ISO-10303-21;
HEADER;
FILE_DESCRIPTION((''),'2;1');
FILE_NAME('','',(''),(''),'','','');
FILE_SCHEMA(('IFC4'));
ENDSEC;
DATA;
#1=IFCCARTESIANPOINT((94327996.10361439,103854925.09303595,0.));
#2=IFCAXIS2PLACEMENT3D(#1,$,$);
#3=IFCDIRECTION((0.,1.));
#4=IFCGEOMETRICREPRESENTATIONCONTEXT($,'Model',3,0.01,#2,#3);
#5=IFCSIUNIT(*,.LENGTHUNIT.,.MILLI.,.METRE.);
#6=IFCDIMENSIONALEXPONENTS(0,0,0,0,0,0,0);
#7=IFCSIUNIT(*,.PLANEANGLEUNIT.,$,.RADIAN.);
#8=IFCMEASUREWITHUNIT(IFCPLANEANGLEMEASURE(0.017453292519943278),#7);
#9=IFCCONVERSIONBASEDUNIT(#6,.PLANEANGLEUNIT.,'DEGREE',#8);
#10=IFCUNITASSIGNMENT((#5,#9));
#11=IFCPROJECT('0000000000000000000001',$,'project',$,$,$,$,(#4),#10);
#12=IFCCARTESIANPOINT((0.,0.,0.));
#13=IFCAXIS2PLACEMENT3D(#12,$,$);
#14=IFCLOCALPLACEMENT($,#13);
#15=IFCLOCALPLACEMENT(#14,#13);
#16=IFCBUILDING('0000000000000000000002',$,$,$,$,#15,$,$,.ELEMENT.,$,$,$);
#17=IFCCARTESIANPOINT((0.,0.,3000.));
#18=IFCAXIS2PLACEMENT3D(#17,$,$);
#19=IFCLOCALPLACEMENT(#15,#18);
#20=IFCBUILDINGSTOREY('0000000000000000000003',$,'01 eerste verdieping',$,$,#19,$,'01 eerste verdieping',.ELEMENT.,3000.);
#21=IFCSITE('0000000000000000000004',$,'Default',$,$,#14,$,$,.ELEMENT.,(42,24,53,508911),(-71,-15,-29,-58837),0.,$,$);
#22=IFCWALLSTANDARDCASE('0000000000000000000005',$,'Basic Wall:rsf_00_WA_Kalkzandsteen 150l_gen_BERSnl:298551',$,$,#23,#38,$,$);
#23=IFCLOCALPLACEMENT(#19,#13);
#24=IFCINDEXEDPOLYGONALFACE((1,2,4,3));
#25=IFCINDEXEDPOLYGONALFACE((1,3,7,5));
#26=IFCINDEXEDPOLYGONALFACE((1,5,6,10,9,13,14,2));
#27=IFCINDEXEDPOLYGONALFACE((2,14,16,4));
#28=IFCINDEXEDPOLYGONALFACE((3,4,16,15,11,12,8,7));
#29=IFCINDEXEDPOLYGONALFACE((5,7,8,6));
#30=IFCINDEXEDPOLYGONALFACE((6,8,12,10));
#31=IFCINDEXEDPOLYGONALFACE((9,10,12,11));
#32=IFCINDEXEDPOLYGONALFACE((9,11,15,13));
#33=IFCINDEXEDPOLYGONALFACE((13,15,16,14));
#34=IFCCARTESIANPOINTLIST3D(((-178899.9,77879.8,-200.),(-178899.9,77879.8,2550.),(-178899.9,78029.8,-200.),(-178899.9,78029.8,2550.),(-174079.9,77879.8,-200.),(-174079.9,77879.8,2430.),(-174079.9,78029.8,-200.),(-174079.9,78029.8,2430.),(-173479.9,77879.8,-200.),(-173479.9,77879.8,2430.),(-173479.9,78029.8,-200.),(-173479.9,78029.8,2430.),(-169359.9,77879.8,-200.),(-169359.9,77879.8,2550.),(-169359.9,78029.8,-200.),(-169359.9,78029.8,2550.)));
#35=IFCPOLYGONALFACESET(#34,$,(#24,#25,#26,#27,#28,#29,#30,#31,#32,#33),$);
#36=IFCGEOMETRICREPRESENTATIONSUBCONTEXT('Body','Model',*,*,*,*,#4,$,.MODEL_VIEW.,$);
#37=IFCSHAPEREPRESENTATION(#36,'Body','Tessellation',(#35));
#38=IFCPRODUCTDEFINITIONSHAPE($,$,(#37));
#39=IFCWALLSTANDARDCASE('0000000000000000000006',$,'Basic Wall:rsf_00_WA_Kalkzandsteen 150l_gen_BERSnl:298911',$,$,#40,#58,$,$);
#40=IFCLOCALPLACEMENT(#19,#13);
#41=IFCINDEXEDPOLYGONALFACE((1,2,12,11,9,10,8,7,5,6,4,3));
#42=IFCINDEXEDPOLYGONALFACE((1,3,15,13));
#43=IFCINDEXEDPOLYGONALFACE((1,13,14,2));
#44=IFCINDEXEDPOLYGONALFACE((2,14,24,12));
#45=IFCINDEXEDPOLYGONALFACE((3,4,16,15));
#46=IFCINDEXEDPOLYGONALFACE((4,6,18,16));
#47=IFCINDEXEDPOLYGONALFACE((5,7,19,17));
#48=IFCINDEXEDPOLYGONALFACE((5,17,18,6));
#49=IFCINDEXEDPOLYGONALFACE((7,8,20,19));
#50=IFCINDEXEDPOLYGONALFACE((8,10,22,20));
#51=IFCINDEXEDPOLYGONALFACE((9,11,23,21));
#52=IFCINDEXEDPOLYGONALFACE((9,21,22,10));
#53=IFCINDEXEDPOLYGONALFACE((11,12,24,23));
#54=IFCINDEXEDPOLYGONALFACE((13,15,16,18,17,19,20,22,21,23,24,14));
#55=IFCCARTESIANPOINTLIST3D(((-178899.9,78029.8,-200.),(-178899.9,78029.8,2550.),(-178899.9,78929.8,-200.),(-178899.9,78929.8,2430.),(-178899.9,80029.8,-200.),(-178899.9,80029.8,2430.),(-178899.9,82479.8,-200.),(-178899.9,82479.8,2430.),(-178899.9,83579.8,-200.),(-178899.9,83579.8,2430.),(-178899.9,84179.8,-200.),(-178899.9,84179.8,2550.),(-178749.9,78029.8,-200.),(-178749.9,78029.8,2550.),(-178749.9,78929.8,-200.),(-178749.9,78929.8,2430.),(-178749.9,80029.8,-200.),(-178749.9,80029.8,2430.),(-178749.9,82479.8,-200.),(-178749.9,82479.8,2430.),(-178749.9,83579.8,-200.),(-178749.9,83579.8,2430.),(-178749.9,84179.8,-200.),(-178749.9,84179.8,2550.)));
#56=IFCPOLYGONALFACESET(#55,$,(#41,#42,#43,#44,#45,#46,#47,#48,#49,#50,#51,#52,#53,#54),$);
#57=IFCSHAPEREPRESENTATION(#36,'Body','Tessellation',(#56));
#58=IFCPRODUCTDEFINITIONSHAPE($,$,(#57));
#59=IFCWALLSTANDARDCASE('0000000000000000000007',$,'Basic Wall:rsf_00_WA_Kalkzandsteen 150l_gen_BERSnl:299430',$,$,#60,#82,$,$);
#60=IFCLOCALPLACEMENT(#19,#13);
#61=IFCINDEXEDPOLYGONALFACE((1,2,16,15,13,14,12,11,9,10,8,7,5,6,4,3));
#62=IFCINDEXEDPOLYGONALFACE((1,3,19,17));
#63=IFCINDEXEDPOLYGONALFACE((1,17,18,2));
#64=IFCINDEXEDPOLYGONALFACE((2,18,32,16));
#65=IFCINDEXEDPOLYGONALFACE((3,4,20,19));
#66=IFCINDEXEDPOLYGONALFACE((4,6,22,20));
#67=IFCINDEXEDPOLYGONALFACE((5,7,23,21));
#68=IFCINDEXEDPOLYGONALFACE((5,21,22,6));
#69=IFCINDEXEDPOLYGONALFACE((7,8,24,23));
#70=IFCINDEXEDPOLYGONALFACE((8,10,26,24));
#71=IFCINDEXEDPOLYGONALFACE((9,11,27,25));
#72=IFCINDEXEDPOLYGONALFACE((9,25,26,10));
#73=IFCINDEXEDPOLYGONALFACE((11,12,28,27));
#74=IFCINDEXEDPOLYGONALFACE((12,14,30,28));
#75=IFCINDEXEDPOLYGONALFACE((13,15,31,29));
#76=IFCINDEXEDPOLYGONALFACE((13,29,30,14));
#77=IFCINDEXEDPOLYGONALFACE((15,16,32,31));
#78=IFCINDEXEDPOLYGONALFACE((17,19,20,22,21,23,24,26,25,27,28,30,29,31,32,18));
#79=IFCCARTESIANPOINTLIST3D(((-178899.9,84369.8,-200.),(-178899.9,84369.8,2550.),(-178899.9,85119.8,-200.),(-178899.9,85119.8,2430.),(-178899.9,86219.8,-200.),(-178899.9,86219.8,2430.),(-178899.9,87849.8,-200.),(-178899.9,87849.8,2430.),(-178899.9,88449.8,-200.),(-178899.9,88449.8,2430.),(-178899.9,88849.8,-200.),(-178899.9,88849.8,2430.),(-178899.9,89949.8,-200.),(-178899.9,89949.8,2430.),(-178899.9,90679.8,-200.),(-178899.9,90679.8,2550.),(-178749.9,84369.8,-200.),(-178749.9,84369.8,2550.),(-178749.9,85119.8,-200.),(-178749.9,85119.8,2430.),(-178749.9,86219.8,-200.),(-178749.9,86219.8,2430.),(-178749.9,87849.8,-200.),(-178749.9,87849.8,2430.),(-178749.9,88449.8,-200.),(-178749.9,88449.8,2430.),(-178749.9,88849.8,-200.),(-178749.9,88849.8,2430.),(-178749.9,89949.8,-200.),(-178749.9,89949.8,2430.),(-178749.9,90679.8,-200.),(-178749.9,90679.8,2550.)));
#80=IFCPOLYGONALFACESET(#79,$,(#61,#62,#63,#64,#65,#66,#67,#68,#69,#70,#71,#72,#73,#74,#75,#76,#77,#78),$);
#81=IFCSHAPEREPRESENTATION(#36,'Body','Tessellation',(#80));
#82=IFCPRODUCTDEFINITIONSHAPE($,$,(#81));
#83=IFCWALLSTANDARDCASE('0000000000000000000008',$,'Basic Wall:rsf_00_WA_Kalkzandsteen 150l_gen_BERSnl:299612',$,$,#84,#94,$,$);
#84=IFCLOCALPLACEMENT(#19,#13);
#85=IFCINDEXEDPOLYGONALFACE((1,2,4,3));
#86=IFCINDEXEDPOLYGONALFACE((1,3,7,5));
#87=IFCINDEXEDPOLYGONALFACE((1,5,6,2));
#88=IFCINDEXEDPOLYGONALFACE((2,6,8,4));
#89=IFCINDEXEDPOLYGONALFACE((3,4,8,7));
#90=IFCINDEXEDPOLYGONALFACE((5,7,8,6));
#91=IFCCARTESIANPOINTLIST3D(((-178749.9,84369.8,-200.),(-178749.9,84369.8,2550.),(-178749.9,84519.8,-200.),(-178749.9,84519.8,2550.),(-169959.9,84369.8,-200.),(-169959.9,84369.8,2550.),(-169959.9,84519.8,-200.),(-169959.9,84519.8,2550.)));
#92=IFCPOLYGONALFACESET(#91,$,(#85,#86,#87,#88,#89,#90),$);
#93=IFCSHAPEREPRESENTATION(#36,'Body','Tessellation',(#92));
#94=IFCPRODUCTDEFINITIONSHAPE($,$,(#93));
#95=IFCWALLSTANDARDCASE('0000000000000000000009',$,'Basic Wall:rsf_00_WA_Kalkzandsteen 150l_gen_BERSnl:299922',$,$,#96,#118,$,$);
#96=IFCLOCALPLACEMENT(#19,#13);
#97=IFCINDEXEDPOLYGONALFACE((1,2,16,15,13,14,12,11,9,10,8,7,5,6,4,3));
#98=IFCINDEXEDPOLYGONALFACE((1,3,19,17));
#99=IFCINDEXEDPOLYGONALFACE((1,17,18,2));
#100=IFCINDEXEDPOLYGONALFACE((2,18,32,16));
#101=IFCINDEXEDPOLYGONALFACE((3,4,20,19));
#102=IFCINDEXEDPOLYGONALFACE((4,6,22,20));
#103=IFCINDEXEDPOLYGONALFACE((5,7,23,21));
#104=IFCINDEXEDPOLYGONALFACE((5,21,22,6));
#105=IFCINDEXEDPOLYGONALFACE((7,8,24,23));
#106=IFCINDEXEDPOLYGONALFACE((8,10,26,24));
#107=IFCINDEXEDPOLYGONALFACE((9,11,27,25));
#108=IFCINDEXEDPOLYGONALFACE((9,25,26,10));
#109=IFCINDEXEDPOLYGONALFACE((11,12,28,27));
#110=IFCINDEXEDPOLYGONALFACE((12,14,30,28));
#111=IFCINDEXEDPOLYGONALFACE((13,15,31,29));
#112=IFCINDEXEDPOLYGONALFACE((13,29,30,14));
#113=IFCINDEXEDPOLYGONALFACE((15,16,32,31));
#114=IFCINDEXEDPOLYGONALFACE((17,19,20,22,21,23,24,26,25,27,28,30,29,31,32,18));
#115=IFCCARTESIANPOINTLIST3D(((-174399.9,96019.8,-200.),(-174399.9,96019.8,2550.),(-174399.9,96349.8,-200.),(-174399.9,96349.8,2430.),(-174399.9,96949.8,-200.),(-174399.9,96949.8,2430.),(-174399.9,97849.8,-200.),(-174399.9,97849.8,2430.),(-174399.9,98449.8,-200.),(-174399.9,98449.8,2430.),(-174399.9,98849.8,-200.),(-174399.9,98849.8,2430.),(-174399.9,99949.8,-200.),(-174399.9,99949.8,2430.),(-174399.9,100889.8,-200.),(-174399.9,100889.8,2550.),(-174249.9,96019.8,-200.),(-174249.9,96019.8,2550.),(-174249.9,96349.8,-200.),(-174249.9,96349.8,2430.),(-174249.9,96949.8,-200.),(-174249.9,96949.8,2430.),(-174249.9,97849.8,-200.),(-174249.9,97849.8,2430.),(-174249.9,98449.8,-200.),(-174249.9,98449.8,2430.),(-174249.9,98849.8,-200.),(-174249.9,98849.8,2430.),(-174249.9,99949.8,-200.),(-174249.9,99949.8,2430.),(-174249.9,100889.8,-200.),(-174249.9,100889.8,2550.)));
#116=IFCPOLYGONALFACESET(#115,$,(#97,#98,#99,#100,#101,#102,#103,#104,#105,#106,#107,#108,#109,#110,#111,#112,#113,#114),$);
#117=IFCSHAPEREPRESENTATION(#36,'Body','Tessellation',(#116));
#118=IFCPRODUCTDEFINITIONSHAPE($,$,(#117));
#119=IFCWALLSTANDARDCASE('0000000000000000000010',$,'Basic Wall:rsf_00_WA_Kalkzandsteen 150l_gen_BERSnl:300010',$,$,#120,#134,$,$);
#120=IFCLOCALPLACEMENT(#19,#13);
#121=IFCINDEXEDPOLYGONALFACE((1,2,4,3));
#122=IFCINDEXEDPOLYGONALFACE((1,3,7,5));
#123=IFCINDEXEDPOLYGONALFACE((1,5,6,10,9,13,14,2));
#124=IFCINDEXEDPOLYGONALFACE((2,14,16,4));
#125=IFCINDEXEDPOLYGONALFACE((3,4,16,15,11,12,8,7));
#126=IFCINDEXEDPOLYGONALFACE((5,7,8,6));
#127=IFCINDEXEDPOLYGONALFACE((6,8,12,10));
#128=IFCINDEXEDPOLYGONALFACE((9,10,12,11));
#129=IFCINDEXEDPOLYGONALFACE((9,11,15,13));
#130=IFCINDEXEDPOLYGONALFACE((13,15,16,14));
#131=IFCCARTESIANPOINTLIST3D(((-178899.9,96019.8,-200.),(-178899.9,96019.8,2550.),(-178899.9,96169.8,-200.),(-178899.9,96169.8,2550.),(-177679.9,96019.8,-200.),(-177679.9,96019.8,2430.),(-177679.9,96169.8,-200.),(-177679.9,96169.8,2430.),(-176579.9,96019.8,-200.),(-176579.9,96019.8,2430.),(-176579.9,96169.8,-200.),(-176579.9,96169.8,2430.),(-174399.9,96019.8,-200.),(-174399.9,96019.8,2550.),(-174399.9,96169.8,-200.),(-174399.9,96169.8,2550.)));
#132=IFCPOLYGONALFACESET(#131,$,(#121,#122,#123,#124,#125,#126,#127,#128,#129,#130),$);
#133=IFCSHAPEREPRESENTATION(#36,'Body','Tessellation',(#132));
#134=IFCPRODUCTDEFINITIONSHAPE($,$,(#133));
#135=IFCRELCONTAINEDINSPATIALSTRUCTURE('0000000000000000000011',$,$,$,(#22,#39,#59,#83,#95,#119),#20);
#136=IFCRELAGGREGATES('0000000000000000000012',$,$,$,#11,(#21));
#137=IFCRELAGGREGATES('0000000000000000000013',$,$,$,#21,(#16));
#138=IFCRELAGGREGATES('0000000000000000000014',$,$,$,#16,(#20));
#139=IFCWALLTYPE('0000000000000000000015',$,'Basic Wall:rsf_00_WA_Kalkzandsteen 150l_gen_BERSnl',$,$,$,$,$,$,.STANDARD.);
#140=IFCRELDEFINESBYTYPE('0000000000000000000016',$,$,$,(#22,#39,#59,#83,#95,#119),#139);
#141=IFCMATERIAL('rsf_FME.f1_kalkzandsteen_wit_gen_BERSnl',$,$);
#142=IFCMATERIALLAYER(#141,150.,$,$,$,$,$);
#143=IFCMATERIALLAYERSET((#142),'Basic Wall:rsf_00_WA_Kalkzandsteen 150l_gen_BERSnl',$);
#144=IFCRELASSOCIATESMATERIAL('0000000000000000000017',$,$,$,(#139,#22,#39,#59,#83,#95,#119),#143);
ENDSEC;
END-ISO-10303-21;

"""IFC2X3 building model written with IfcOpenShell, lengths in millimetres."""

from ifc_helpers import new_model, entity, si_unit, converted_unit, direction, frame, frame_2d, origin, origin_2d_with_axis, place, context, subcontext, project, spatial, polyline, rectangle, extrude, clip, bounded_halfspace, material, layer, layer_set, layer_usage, type_object, element, save


model = new_model("IFC2X3")

# Units and contexts
model_context = context("Model", 3, precision=0.01, world=frame((94327996.10361439, 103854925.09303595, 0.0)), true_north=direction((0.0, 1.0)))
body_context = subcontext(model_context, "Body", "Model", "MODEL_VIEW")
ifc_project = project(units=[si_unit("LENGTHUNIT", "METRE", prefix="MILLI"), converted_unit("PLANEANGLEUNIT", "DEGREE", entity("IfcPlaneAngleMeasure", 0.017453292519943278), si_unit("PLANEANGLEUNIT", "RADIAN"), dimensions=[0, 0, 0, 0, 0, 0, 0])], contexts=[model_context])

# Site, building, storey
site_placement = place(None, origin())
site = spatial("IfcSite", under=ifc_project, at=site_placement, Name="Default", CompositionType="ELEMENT", RefLatitude=(42, 24, 53, 508911), RefLongitude=(-71, -15, -29, -58837), RefElevation=0.0)
building_placement = place(site_placement, origin())
building = spatial("IfcBuilding", under=site, at=building_placement, CompositionType="ELEMENT")
storey_placement = place(building_placement, frame((0.0, 0.0, 3000.0)))
storey = spatial("IfcBuildingStorey", under=building, at=storey_placement, Name="01 eerste verdieping", LongName="01 eerste verdieping", CompositionType="ELEMENT", Elevation=3000.0)

# Wall, opening
ifc_material = material(Name="rsf_FME.f1_kalkzandsteen_wit_gen_BERSnl")
ifc_layer = layer(ifc_material, 150.0)
ifc_layer_set = layer_set([ifc_layer], Name="Basic Wall:rsf_00_WA_Kalkzandsteen 150l_gen_BERSnl")
ifc_layer_usage_1 = layer_usage(ifc_layer_set, "AXIS2", "NEGATIVE", 75.0)
wall_type = type_object("IfcWallType", Name="Basic Wall:rsf_00_WA_Kalkzandsteen 150l_gen_BERSnl", PredefinedType="STANDARD", material=ifc_layer_set)
wall_1_placement = place(storey_placement, frame((-178899.9, 77954.8, -200.0)))
wall_1 = element("IfcWallStandardCase", 1, at=wall_1_placement, inside=storey, type_object=wall_type, material=ifc_layer_usage_1, Name="Basic Wall:rsf_00_WA_Kalkzandsteen 150l_gen_BERSnl:298551", context=body_context, shape_type="Clipping", body=[
    clip(extrude(rectangle(XDim=9540.0, YDim=150.0, at=frame_2d((4770.0, 0.0), x_axis=(1.0, 0.0))), origin(), (0.0, 0.0, 1.0), 2750.0), bounded_halfspace(frame((0.0, -75.0, 2750.0), z_axis=(0.0, 0.0, -1.0), x_axis=(0.0, 1.0, 0.0)), True, frame((0.0, -75.0, 2750.0)), polyline([(0.0, 0.0), (9540.0, 0.0), (9540.0, 150.0), (9390.0, 150.0), (150.0, 150.0), (0.0, 150.0), (0.0, 0.0)]))),
])
opening_1_placement = place(wall_1_placement, frame((178899.9, -77954.8, 200.0)))
element("IfcOpeningElement", 2, at=opening_1_placement, cuts=wall_1, ObjectType="Opening", context=body_context, shape_type="SweptSolid", body=[
    extrude(rectangle(XDim=2630.0, YDim=600.0, at=origin_2d_with_axis()), frame((-173779.9, 76505.8, 1115.0), z_axis=(0.0, 1.0, 0.0), x_axis=(0.0, 0.0, 1.0)), (0.0, 0.0, 1.0), 3048.0),
])

# Walls, openings
ifc_layer_usage_2 = layer_usage(ifc_layer_set, "AXIS2", "NEGATIVE", 75.0)
wall_2_placement = place(storey_placement, frame((-178824.9, 84179.8, -200.0), z_axis=(0.0, 0.0, 1.0), x_axis=(0.0, -1.0, 0.0)))
wall_2 = element("IfcWallStandardCase", 3, at=wall_2_placement, inside=storey, type_object=wall_type, material=ifc_layer_usage_2, Name="Basic Wall:rsf_00_WA_Kalkzandsteen 150l_gen_BERSnl:298911", context=body_context, shape_type="Clipping", body=[
    clip(extrude(rectangle(XDim=6150.0, YDim=150.0, at=frame_2d((3075.0, 0.0), x_axis=(1.0, 0.0))), origin(), (0.0, 0.0, 1.0), 2750.0), bounded_halfspace(frame((0.0, -75.0, 2750.0), z_axis=(0.0, 0.0, -1.0), x_axis=(-1.0, 0.0, 0.0)), True, frame((0.0, -75.0, 2750.0)), polyline([(0.0, 0.0), (6150.0, 0.0), (6150.0, 150.0), (0.0, 150.0), (0.0, 0.0)]))),
])
opening_2_placement = place(wall_2_placement, frame((84179.8, 178824.9, 200.0), z_axis=(0.0, 0.0, 1.0), x_axis=(0.0, 1.0, 0.0)))
element("IfcOpeningElement", 4, at=opening_2_placement, cuts=wall_2, ObjectType="Opening", context=body_context, shape_type="SweptSolid", body=[
    extrude(rectangle(XDim=2630.0, YDim=1100.0, at=frame_2d((0.0, 0.0), x_axis=(1.0, 0.0))), frame((-180273.9, 83029.8, 1115.0), z_axis=(1.0, 0.0, 0.0), x_axis=(0.0, 0.0, 1.0)), (0.0, 0.0, 1.0), 3048.0),
])
opening_3_placement = place(wall_2_placement, frame((84179.8, 178824.9, 200.0), z_axis=(0.0, 0.0, 1.0), x_axis=(0.0, 1.0, 0.0)))
element("IfcOpeningElement", 5, at=opening_3_placement, cuts=wall_2, ObjectType="Opening", context=body_context, shape_type="SweptSolid", body=[
    extrude(rectangle(XDim=2630.0, YDim=1100.0, at=frame_2d((0.0, 0.0), x_axis=(0.0, 1.0))), frame((-180423.9, 79479.8, 1115.0), z_axis=(1.0, 0.0, 0.0), x_axis=(0.0, 1.0, 0.0)), (0.0, 0.0, 1.0), 3048.0),
])
ifc_layer_usage_3 = layer_usage(ifc_layer_set, "AXIS2", "NEGATIVE", 75.0)
wall_3_placement = place(storey_placement, frame((-178824.9, 90679.8, -200.0), z_axis=(0.0, 0.0, 1.0), x_axis=(0.0, -1.0, 0.0)))
wall_3 = element("IfcWallStandardCase", 6, at=wall_3_placement, inside=storey, type_object=wall_type, material=ifc_layer_usage_3, Name="Basic Wall:rsf_00_WA_Kalkzandsteen 150l_gen_BERSnl:299430", context=body_context, shape_type="Clipping", body=[
    clip(extrude(rectangle(XDim=6310.0, YDim=150.0, at=frame_2d((3155.0, 0.0), x_axis=(1.0, 0.0))), origin(), (0.0, 0.0, 1.0), 2750.0), bounded_halfspace(frame((0.0, -75.0, 2750.0), z_axis=(0.0, 0.0, -1.0), x_axis=(-1.0, 0.0, 0.0)), True, frame((0.0, -75.0, 2750.0)), polyline([(0.0, 0.0), (6310.0, 0.0), (6310.0, 150.0), (6160.0, 150.0), (0.0, 150.0), (0.0, 0.0)]))),
])
opening_4_placement = place(wall_3_placement, frame((90679.8, 178824.9, 200.0), z_axis=(0.0, 0.0, 1.0), x_axis=(0.0, 1.0, 0.0)))
element("IfcOpeningElement", 7, at=opening_4_placement, cuts=wall_3, ObjectType="Opening", context=body_context, shape_type="SweptSolid", body=[
    extrude(rectangle(XDim=2630.0, YDim=1100.0, at=frame_2d((0.0, 0.0), x_axis=(1.0, 0.0))), frame((-180273.9, 89399.8, 1115.0), z_axis=(1.0, 0.0, 0.0), x_axis=(0.0, 0.0, 1.0)), (0.0, 0.0, 1.0), 3048.0),
])
opening_5_placement = place(wall_3_placement, frame((90679.8, 178824.9, 200.0), z_axis=(0.0, 0.0, 1.0), x_axis=(0.0, 1.0, 0.0)))
element("IfcOpeningElement", 8, at=opening_5_placement, cuts=wall_3, ObjectType="Opening", context=body_context, shape_type="SweptSolid", body=[
    extrude(rectangle(XDim=2630.0, YDim=600.0, at=frame_2d((0.0, 0.0), x_axis=(0.0, 1.0))), frame((-180423.9, 88149.8, 1115.0), z_axis=(1.0, 0.0, 0.0), x_axis=(0.0, 1.0, 0.0)), (0.0, 0.0, 1.0), 3048.0),
])
opening_6_placement = place(wall_3_placement, frame((90679.8, 178824.9, 200.0), z_axis=(0.0, 0.0, 1.0), x_axis=(0.0, 1.0, 0.0)))
element("IfcOpeningElement", 9, at=opening_6_placement, cuts=wall_3, ObjectType="Opening", context=body_context, shape_type="SweptSolid", body=[
    extrude(rectangle(XDim=2630.0, YDim=1100.0, at=frame_2d((0.0, 0.0), x_axis=(0.0, 1.0))), frame((-180423.9, 85669.8, 1115.0), z_axis=(1.0, 0.0, 0.0), x_axis=(0.0, 1.0, 0.0)), (0.0, 0.0, 1.0), 3048.0),
])

# Wall
ifc_layer_usage_4 = layer_usage(ifc_layer_set, "AXIS2", "NEGATIVE", 75.0)
wall_4_placement = place(storey_placement, frame((-178749.9, 84444.8, -200.0)))
element("IfcWallStandardCase", 10, at=wall_4_placement, inside=storey, type_object=wall_type, material=ifc_layer_usage_4, Name="Basic Wall:rsf_00_WA_Kalkzandsteen 150l_gen_BERSnl:299612", context=body_context, shape_type="Clipping", body=[
    clip(extrude(rectangle(XDim=8790.0, YDim=150.0, at=frame_2d((4395.0, 0.0), x_axis=(-1.0, 0.0))), origin(), (0.0, 0.0, 1.0), 2750.0), bounded_halfspace(frame((0.0, -75.0, 2750.0), z_axis=(0.0, 0.0, -1.0), x_axis=(0.0, 1.0, 0.0)), True, frame((0.0, -75.0, 2750.0)), polyline([(0.0, 0.0), (8790.0, 0.0), (8790.0, 150.0), (0.0, 150.0), (0.0, 0.0)]))),
])

# Wall, openings
ifc_layer_usage_5 = layer_usage(ifc_layer_set, "AXIS2", "NEGATIVE", 75.0)
wall_5_placement = place(storey_placement, frame((-174324.9, 100889.8, -200.0), z_axis=(0.0, 0.0, 1.0), x_axis=(0.0, -1.0, 0.0)))
wall_5 = element("IfcWallStandardCase", 11, at=wall_5_placement, inside=storey, type_object=wall_type, material=ifc_layer_usage_5, Name="Basic Wall:rsf_00_WA_Kalkzandsteen 150l_gen_BERSnl:299922", context=body_context, shape_type="Clipping", body=[
    clip(extrude(rectangle(XDim=4870.0, YDim=150.0, at=frame_2d((2435.0, 0.0), x_axis=(-1.0, 0.0))), origin(), (0.0, 0.0, 1.0), 2750.0), bounded_halfspace(frame((4870.0, 75.0, 2750.0), z_axis=(0.0, 0.0, -1.0), x_axis=(-1.0, 0.0, 0.0)), True, frame((4870.0, 75.0, 2750.0)), polyline([(0.0, 0.0), (-4870.0, 0.0), (-4870.0, -150.0), (-150.0, -150.0), (0.0, -150.0), (0.0, 0.0)]))),
])
opening_7_placement = place(wall_5_placement, frame((100889.8, 174324.9, 200.0), z_axis=(0.0, 0.0, 1.0), x_axis=(0.0, 1.0, 0.0)))
element("IfcOpeningElement", 12, at=opening_7_placement, cuts=wall_5, ObjectType="Opening", context=body_context, shape_type="SweptSolid", body=[
    extrude(rectangle(XDim=2630.0, YDim=1100.0, at=frame_2d((0.0, 0.0), x_axis=(0.0, 1.0))), frame((-175923.9, 99399.8, 1115.0), z_axis=(1.0, 0.0, 0.0), x_axis=(0.0, 1.0, 0.0)), (0.0, 0.0, 1.0), 3048.0),
])
opening_8_placement = place(wall_5_placement, frame((100889.8, 174324.9, 200.0), z_axis=(0.0, 0.0, 1.0), x_axis=(0.0, 1.0, 0.0)))
element("IfcOpeningElement", 13, at=opening_8_placement, cuts=wall_5, ObjectType="Opening", context=body_context, shape_type="SweptSolid", body=[
    extrude(rectangle(XDim=2630.0, YDim=600.0, at=frame_2d((0.0, 0.0), x_axis=(0.0, 1.0))), frame((-175923.9, 98149.8, 1115.0), z_axis=(1.0, 0.0, 0.0), x_axis=(0.0, 1.0, 0.0)), (0.0, 0.0, 1.0), 3048.0),
])
opening_9_placement = place(wall_5_placement, frame((100889.8, 174324.9, 200.0), z_axis=(0.0, 0.0, 1.0), x_axis=(0.0, 1.0, 0.0)))
element("IfcOpeningElement", 14, at=opening_9_placement, cuts=wall_5, ObjectType="Opening", context=body_context, shape_type="SweptSolid", body=[
    extrude(rectangle(XDim=2630.0, YDim=600.0, at=frame_2d((0.0, 0.0), x_axis=(0.0, 1.0))), frame((-175923.9, 96649.8, 1115.0), z_axis=(1.0, 0.0, 0.0), x_axis=(0.0, 1.0, 0.0)), (0.0, 0.0, 1.0), 3048.0),
])

# Wall, opening
ifc_layer_usage_6 = layer_usage(ifc_layer_set, "AXIS2", "NEGATIVE", 75.0)
wall_6_placement = place(storey_placement, frame((-174399.9, 96094.8, -200.0), z_axis=(0.0, 0.0, 1.0), x_axis=(-1.0, 0.0, 0.0)))
wall_6 = element("IfcWallStandardCase", 15, at=wall_6_placement, inside=storey, type_object=wall_type, material=ifc_layer_usage_6, Name="Basic Wall:rsf_00_WA_Kalkzandsteen 150l_gen_BERSnl:300010", context=body_context, shape_type="Clipping", body=[
    clip(extrude(rectangle(XDim=4500.0, YDim=150.0, at=frame_2d((2250.0, 0.0), x_axis=(-1.0, 0.0))), origin(), (0.0, 0.0, 1.0), 2750.0), bounded_halfspace(frame((0.0, -75.0, 2750.0), z_axis=(0.0, 0.0, -1.0), x_axis=(0.0, -1.0, 0.0)), True, frame((0.0, -75.0, 2750.0)), polyline([(0.0, 0.0), (4500.0, 0.0), (4500.0, 150.0), (4350.0, 150.0), (0.0, 150.0), (0.0, 0.0)]))),
])
opening_10_placement = place(wall_6_placement, frame((-174399.9, 96094.8, 200.0), z_axis=(0.0, 0.0, 1.0), x_axis=(-1.0, 0.0, 0.0)))
element("IfcOpeningElement", 16, at=opening_10_placement, cuts=wall_6, ObjectType="Opening", context=body_context, shape_type="SweptSolid", body=[
    extrude(rectangle(XDim=2630.0, YDim=1100.0, at=frame_2d((0.0, 0.0), x_axis=(0.0, 1.0))), frame((-177129.9, 97693.8, 1115.0), z_axis=(0.0, -1.0, 0.0), x_axis=(1.0, 0.0, 0.0)), (0.0, 0.0, 1.0), 3048.0),
])

save(model, "model.ifc")
